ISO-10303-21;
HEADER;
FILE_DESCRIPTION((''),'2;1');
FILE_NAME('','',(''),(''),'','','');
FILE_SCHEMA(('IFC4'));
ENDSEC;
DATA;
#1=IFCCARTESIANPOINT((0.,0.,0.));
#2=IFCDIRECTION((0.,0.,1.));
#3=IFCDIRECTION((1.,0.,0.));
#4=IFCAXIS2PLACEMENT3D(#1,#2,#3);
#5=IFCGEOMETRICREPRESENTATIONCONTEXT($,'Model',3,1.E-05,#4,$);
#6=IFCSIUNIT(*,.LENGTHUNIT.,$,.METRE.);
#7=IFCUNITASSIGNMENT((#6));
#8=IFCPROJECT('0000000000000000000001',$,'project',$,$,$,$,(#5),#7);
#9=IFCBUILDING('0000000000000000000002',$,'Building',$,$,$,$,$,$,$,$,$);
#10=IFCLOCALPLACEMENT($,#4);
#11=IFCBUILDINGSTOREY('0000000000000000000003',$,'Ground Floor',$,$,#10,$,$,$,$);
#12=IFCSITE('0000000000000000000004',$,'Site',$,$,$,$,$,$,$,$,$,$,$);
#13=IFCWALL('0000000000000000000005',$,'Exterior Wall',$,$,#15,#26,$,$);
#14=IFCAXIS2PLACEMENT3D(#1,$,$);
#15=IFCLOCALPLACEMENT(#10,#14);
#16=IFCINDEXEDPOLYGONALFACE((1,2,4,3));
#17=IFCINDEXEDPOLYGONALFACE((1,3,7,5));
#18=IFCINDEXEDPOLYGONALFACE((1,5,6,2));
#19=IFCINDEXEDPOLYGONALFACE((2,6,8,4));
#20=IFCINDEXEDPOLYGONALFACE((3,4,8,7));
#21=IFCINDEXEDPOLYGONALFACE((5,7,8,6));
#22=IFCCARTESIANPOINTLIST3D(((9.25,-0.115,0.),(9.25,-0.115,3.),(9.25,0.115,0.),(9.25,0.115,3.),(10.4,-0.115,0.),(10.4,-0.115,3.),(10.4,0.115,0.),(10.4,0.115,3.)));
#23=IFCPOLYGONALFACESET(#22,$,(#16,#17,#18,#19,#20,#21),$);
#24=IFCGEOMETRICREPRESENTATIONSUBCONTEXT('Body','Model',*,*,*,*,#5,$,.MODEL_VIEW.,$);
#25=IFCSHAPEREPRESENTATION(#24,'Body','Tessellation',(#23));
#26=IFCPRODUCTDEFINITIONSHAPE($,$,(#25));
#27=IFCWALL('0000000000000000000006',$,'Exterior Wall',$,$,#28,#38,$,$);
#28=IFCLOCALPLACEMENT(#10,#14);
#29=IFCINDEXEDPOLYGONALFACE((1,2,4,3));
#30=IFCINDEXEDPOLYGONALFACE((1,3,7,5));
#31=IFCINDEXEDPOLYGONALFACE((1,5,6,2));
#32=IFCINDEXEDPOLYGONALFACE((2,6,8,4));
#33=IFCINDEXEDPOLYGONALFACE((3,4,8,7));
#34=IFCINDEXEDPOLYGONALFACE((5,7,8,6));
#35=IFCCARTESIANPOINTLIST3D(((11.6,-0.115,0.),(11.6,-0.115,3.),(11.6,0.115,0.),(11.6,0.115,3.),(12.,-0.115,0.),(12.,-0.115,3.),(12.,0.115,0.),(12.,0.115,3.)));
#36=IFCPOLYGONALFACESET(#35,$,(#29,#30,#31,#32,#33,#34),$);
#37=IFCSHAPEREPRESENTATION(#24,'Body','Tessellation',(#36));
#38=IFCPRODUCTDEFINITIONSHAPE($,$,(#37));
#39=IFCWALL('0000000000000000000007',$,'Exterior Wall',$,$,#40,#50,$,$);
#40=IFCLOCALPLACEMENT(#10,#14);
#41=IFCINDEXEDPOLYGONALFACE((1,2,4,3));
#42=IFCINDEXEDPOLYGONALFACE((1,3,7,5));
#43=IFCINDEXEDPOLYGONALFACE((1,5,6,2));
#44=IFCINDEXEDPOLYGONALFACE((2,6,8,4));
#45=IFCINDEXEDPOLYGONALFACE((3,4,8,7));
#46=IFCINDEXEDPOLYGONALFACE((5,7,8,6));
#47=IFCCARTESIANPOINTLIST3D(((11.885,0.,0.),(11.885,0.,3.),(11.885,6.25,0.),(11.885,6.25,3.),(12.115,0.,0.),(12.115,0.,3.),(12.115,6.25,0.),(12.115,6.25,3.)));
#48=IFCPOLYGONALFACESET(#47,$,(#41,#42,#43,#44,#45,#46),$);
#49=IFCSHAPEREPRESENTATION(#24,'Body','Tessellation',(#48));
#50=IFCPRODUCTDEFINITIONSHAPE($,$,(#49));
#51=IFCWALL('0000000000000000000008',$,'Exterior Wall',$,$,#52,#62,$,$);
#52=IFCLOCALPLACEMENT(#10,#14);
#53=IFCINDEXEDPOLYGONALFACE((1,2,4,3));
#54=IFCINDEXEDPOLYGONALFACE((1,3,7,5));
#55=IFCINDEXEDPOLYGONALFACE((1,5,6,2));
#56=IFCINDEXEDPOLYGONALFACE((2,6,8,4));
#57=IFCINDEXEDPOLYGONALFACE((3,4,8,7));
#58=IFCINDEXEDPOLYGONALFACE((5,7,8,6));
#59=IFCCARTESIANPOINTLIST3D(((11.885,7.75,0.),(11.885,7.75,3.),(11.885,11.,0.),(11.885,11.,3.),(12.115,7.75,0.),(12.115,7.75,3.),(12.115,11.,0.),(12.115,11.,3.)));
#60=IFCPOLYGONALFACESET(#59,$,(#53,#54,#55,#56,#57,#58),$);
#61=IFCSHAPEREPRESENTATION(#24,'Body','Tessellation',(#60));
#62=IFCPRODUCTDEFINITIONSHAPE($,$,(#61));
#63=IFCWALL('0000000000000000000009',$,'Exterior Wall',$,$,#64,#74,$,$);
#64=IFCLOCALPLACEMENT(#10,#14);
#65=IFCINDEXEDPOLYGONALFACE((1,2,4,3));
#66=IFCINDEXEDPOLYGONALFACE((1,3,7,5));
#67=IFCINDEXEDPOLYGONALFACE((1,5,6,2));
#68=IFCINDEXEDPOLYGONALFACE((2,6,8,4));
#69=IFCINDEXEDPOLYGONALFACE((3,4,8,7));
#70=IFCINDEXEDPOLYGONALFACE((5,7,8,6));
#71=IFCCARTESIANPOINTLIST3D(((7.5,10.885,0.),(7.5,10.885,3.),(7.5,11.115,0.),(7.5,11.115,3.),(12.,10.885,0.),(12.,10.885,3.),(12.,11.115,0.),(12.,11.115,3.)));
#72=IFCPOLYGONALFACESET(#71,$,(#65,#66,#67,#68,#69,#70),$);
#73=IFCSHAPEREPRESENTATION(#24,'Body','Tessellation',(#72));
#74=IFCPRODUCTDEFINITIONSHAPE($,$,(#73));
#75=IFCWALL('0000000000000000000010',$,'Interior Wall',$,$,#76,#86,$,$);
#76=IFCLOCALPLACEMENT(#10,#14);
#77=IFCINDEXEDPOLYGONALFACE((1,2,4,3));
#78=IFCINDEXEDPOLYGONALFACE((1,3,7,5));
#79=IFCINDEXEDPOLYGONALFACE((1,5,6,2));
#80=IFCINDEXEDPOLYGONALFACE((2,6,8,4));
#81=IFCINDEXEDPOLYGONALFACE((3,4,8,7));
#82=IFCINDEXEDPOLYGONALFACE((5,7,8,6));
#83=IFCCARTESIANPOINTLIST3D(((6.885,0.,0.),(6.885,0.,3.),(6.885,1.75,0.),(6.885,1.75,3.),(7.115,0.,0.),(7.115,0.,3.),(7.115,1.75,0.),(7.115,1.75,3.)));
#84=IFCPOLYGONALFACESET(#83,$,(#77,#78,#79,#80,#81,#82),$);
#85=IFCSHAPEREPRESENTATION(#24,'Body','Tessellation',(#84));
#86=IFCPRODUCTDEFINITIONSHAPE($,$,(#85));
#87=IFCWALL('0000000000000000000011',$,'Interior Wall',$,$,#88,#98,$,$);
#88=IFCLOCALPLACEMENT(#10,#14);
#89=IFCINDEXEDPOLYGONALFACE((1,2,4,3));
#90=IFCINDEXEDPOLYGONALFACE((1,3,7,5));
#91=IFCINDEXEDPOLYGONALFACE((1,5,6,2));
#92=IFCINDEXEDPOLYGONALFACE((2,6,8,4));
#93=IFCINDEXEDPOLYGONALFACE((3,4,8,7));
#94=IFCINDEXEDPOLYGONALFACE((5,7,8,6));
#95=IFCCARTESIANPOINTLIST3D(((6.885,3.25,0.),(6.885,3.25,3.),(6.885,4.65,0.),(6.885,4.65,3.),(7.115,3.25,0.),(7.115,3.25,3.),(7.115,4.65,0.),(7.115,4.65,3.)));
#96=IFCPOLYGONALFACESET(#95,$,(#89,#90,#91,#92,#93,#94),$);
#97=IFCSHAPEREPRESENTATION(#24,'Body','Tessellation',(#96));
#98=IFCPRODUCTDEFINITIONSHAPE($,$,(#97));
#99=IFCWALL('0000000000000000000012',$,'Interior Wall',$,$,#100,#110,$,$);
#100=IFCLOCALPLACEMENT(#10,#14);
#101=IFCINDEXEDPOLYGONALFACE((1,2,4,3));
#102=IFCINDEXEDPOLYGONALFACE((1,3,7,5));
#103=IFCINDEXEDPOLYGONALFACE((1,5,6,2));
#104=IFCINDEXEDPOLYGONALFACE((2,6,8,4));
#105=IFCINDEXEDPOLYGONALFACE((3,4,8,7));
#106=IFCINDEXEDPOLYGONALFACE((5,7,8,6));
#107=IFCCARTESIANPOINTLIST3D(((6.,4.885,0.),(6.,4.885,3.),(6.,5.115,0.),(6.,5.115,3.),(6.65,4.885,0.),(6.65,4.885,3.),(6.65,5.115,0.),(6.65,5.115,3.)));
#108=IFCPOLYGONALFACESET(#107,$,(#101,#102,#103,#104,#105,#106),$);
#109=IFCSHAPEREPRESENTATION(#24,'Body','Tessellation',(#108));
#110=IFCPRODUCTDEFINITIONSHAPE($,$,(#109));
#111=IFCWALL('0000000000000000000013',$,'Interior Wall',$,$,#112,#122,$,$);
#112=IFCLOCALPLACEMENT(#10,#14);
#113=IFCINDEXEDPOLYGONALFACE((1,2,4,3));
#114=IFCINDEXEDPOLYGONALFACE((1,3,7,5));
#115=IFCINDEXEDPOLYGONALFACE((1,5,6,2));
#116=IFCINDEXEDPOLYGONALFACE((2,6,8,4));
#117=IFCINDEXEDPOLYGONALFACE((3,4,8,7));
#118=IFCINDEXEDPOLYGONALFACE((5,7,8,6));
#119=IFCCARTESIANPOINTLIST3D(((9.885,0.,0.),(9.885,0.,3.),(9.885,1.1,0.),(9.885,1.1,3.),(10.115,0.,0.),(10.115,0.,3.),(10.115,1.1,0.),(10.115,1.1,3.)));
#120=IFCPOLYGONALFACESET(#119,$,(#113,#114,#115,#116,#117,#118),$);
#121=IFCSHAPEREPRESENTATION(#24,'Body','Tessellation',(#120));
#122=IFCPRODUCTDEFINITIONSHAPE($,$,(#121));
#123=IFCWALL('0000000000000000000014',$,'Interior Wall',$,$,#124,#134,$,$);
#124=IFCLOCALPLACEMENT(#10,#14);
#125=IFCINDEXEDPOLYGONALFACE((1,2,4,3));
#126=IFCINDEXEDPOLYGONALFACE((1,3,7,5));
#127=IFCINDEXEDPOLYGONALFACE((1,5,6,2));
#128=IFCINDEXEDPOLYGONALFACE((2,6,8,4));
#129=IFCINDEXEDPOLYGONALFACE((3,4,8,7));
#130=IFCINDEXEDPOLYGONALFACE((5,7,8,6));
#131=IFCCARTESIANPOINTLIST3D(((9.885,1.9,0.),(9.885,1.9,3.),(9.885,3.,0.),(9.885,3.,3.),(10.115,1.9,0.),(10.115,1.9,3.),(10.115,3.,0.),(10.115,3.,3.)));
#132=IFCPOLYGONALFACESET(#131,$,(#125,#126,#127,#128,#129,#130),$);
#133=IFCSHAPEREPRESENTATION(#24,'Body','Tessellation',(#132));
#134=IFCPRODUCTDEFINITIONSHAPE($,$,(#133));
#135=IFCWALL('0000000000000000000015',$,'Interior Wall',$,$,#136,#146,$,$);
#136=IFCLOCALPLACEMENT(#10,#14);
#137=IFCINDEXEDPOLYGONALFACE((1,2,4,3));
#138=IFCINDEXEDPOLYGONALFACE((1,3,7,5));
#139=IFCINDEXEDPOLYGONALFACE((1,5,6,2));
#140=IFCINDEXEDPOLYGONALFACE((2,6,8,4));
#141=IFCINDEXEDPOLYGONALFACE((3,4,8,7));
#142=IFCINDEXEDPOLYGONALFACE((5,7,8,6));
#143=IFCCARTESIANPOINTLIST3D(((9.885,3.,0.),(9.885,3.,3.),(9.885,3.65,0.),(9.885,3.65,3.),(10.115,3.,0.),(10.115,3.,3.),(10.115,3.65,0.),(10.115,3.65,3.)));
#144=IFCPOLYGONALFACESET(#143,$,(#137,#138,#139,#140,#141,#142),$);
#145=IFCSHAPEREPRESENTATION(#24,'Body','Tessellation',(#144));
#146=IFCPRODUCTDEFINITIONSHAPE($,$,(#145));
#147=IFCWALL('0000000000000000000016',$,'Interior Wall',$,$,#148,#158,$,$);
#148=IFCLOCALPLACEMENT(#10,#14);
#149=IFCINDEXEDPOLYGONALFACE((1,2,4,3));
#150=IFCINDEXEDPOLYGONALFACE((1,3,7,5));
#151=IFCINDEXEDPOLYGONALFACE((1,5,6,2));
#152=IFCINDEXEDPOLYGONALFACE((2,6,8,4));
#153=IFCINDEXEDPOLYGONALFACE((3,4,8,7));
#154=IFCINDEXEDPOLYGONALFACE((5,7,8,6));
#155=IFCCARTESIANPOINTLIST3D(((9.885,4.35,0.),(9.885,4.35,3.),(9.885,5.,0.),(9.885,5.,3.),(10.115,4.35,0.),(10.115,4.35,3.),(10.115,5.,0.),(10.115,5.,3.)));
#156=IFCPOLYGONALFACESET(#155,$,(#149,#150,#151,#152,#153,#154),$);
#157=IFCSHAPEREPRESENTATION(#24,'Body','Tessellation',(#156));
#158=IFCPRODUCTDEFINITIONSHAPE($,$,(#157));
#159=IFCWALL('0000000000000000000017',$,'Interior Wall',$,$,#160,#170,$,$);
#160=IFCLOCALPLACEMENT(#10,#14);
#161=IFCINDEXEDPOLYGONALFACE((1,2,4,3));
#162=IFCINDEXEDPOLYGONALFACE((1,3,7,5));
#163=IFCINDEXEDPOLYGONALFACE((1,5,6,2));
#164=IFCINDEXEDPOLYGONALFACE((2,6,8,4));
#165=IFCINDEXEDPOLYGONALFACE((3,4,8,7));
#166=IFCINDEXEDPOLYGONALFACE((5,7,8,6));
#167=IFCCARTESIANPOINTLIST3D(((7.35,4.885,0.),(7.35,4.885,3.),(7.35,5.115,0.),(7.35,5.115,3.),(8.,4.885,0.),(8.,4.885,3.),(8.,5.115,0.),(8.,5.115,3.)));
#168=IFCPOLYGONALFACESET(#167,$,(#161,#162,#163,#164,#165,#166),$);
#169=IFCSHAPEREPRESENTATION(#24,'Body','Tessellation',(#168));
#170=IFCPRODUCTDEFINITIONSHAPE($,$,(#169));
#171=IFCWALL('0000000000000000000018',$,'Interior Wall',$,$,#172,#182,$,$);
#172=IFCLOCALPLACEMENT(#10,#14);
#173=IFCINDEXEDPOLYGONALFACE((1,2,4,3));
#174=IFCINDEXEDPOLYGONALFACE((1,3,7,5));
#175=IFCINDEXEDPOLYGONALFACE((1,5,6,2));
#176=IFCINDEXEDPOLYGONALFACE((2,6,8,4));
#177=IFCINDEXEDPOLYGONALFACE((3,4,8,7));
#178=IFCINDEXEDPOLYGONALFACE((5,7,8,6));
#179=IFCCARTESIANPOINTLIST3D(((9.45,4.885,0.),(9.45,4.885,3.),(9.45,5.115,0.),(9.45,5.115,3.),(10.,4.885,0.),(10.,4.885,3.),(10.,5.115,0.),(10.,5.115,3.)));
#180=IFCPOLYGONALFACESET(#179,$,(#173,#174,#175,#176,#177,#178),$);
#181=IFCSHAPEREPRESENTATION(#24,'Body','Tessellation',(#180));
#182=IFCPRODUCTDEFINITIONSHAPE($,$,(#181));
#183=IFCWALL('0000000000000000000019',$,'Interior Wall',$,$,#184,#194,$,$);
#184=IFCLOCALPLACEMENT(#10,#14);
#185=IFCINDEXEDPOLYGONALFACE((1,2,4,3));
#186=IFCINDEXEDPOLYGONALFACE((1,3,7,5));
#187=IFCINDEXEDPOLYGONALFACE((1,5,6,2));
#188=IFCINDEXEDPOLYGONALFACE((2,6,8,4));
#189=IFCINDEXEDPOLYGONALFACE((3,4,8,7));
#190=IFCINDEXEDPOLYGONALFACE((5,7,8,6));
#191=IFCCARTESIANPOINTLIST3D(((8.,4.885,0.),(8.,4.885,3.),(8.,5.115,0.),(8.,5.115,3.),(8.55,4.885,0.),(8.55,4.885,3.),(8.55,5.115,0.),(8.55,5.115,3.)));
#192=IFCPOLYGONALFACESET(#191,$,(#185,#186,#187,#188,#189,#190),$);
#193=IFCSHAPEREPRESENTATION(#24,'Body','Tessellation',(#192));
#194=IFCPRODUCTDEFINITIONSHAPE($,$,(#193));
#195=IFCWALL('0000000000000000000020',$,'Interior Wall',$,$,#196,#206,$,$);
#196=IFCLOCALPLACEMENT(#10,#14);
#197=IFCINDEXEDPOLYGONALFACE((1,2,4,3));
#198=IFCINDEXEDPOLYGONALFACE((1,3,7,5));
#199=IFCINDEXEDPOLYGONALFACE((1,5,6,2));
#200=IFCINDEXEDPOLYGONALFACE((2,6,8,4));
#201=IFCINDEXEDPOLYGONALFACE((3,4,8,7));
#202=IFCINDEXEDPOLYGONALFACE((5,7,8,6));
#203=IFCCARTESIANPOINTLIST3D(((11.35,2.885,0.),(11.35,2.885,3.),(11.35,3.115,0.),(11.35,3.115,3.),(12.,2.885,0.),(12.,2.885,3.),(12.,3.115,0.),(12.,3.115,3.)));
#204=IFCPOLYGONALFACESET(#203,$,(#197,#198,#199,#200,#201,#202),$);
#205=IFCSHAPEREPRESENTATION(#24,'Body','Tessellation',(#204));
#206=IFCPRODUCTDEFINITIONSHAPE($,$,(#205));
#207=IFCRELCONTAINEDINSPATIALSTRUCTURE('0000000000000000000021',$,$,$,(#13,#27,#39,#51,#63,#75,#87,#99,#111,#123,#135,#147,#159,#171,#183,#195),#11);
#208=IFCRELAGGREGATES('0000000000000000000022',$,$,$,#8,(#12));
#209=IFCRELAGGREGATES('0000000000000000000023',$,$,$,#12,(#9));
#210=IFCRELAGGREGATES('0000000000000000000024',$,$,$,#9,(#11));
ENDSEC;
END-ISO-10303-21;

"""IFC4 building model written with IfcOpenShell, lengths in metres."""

from ifc_helpers import new_model, si_unit, frame, origin_with_axes, place, context, subcontext, project, spatial, indexed_curve, outline, extrude, element, save


model = new_model("IFC4")

# Units and contexts
model_context = context("Model", 3, precision=1e-05, world=origin_with_axes())
body_context = subcontext(model_context, "Body", "Model", "MODEL_VIEW")
ifc_project = project(units=[si_unit("LENGTHUNIT", "METRE")], contexts=[model_context])

# Site, building, storey
site = spatial("IfcSite", under=ifc_project, Name="Site")
building = spatial("IfcBuilding", under=site, Name="Building")
storey_placement = place(None, origin_with_axes())
storey = spatial("IfcBuildingStorey", under=building, at=storey_placement, Name="Ground Floor")

# Walls
wall_1_placement = place(storey_placement, frame((9.25, 0.0, 0.0), z_axis=(0.0, 0.0, 1.0), x_axis=(1.0, 0.0, 0.0)))
element("IfcWall", 1, at=wall_1_placement, inside=storey, Name="Exterior Wall", context=body_context, shape_type="SweptSolid", body=[
    extrude(outline(indexed_curve([(0.0, 0.0), (0.0, 0.23), (1.15, 0.23), (1.15, 0.0), (0.0, 0.0)], self_intersect=False)), frame((0.0, -0.115, 0.0), z_axis=(0.0, 0.0, 1.0), x_axis=(1.0, 0.0, 0.0)), (0.0, 0.0, 1.0), 3.0),
])
wall_2_placement = place(storey_placement, frame((11.6, 0.0, 0.0), z_axis=(0.0, 0.0, 1.0), x_axis=(1.0, 0.0, 0.0)))
element("IfcWall", 2, at=wall_2_placement, inside=storey, Name="Exterior Wall", context=body_context, shape_type="SweptSolid", body=[
    extrude(outline(indexed_curve([(0.0, 0.0), (0.0, 0.23), (0.4, 0.23), (0.4, 0.0), (0.0, 0.0)], self_intersect=False)), frame((0.0, -0.115, 0.0), z_axis=(0.0, 0.0, 1.0), x_axis=(1.0, 0.0, 0.0)), (0.0, 0.0, 1.0), 3.0),
])
wall_3_placement = place(storey_placement, frame((12.0, 0.0, 0.0), z_axis=(0.0, 0.0, 1.0), x_axis=(0.0, 1.0, 0.0)))
element("IfcWall", 3, at=wall_3_placement, inside=storey, Name="Exterior Wall", context=body_context, shape_type="SweptSolid", body=[
    extrude(outline(indexed_curve([(0.0, 0.0), (0.0, 0.23), (6.25, 0.23), (6.25, 0.0), (0.0, 0.0)], self_intersect=False)), frame((0.0, -0.115, 0.0), z_axis=(0.0, 0.0, 1.0), x_axis=(1.0, 0.0, 0.0)), (0.0, 0.0, 1.0), 3.0),
])
wall_4_placement = place(storey_placement, frame((12.0, 7.75, 0.0), z_axis=(0.0, 0.0, 1.0), x_axis=(0.0, 1.0, 0.0)))
element("IfcWall", 4, at=wall_4_placement, inside=storey, Name="Exterior Wall", context=body_context, shape_type="SweptSolid", body=[
    extrude(outline(indexed_curve([(0.0, 0.0), (0.0, 0.23), (3.25, 0.23), (3.25, 0.0), (0.0, 0.0)], self_intersect=False)), frame((0.0, -0.115, 0.0), z_axis=(0.0, 0.0, 1.0), x_axis=(1.0, 0.0, 0.0)), (0.0, 0.0, 1.0), 3.0),
])
wall_5_placement = place(storey_placement, frame((12.0, 11.0, 0.0), z_axis=(0.0, 0.0, 1.0), x_axis=(-1.0, 0.0, 0.0)))
element("IfcWall", 5, at=wall_5_placement, inside=storey, Name="Exterior Wall", context=body_context, shape_type="SweptSolid", body=[
    extrude(outline(indexed_curve([(0.0, 0.0), (0.0, 0.23), (4.5, 0.23), (4.5, 0.0), (0.0, 0.0)], self_intersect=False)), frame((0.0, -0.115, 0.0), z_axis=(0.0, 0.0, 1.0), x_axis=(1.0, 0.0, 0.0)), (0.0, 0.0, 1.0), 3.0),
])
wall_6_placement = place(storey_placement, frame((7.0, 0.0, 0.0), z_axis=(0.0, 0.0, 1.0), x_axis=(0.0, 1.0, 0.0)))
element("IfcWall", 6, at=wall_6_placement, inside=storey, Name="Interior Wall", context=body_context, shape_type="SweptSolid", body=[
    extrude(outline(indexed_curve([(0.0, 0.0), (0.0, 0.23), (1.75, 0.23), (1.75, 0.0), (0.0, 0.0)], self_intersect=False)), frame((0.0, -0.115, 0.0), z_axis=(0.0, 0.0, 1.0), x_axis=(1.0, 0.0, 0.0)), (0.0, 0.0, 1.0), 3.0),
])
wall_7_placement = place(storey_placement, frame((7.0, 3.25, 0.0), z_axis=(0.0, 0.0, 1.0), x_axis=(0.0, 1.0, 0.0)))
element("IfcWall", 7, at=wall_7_placement, inside=storey, Name="Interior Wall", context=body_context, shape_type="SweptSolid", body=[
    extrude(outline(indexed_curve([(0.0, 0.0), (0.0, 0.23), (1.4, 0.23), (1.4, 0.0), (0.0, 0.0)], self_intersect=False)), frame((0.0, -0.115, 0.0), z_axis=(0.0, 0.0, 1.0), x_axis=(1.0, 0.0, 0.0)), (0.0, 0.0, 1.0), 3.0),
])
wall_8_placement = place(storey_placement, frame((6.65, 5.0, 0.0), z_axis=(0.0, 0.0, 1.0), x_axis=(-1.0, 0.0, 0.0)))
element("IfcWall", 8, at=wall_8_placement, inside=storey, Name="Interior Wall", context=body_context, shape_type="SweptSolid", body=[
    extrude(outline(indexed_curve([(0.0, 0.0), (0.0, 0.23), (0.65, 0.23), (0.65, 0.0), (0.0, 0.0)], self_intersect=False)), frame((0.0, -0.115, 0.0), z_axis=(0.0, 0.0, 1.0), x_axis=(1.0, 0.0, 0.0)), (0.0, 0.0, 1.0), 3.0),
])
for number, where, z_axis, x_axis, name in (
    (9, (10.0, 0.0, 0.0), (0.0, 0.0, 1.0), (0.0, 1.0, 0.0), "Interior Wall"),
    (10, (10.0, 1.9, 0.0), (0.0, 0.0, 1.0), (0.0, 1.0, 0.0), "Interior Wall"),
):
    element("IfcWall", number, at=place(storey_placement, frame(where, z_axis=z_axis, x_axis=x_axis)), inside=storey, Name=name, context=body_context, shape_type="SweptSolid", body=[
        extrude(outline(indexed_curve([(0.0, 0.0), (0.0, 0.23), (1.1, 0.23), (1.1, 0.0), (0.0, 0.0)], self_intersect=False)), frame((0.0, -0.115, 0.0), z_axis=(0.0, 0.0, 1.0), x_axis=(1.0, 0.0, 0.0)), (0.0, 0.0, 1.0), 3.0),
    ])
wall_9_placement = place(storey_placement, frame((10.0, 3.0, 0.0), z_axis=(0.0, 0.0, 1.0), x_axis=(0.0, 1.0, 0.0)))
element("IfcWall", 11, at=wall_9_placement, inside=storey, Name="Interior Wall", context=body_context, shape_type="SweptSolid", body=[
    extrude(outline(indexed_curve([(0.0, 0.0), (0.0, 0.23), (0.65, 0.23), (0.65, 0.0), (0.0, 0.0)], self_intersect=False)), frame((0.0, -0.115, 0.0), z_axis=(0.0, 0.0, 1.0), x_axis=(1.0, 0.0, 0.0)), (0.0, 0.0, 1.0), 3.0),
])
for number, where, z_axis, x_axis, name in (
    (12, (10.0, 4.35, 0.0), (0.0, 0.0, 1.0), (0.0, 1.0, 0.0), "Interior Wall"),
    (13, (8.0, 5.0, 0.0), (0.0, 0.0, 1.0), (-1.0, 0.0, 0.0), "Interior Wall"),
):
    element("IfcWall", number, at=place(storey_placement, frame(where, z_axis=z_axis, x_axis=x_axis)), inside=storey, Name=name, context=body_context, shape_type="SweptSolid", body=[
        extrude(outline(indexed_curve([(0.0, 0.0), (0.0, 0.23), (0.65, 0.23), (0.65, 0.0), (0.0, 0.0)], self_intersect=False)), frame((0.0, -0.115, 0.0), z_axis=(0.0, 0.0, 1.0), x_axis=(1.0, 0.0, 0.0)), (0.0, 0.0, 1.0), 3.0),
    ])
for number, where, z_axis, x_axis, name in (
    (14, (10.0, 5.0, 0.0), (0.0, 0.0, 1.0), (-1.0, 0.0, 0.0), "Interior Wall"),
    (15, (8.55, 5.0, 0.0), (0.0, 0.0, 1.0), (-1.0, 0.0, 0.0), "Interior Wall"),
):
    element("IfcWall", number, at=place(storey_placement, frame(where, z_axis=z_axis, x_axis=x_axis)), inside=storey, Name=name, context=body_context, shape_type="SweptSolid", body=[
        extrude(outline(indexed_curve([(0.0, 0.0), (0.0, 0.23), (0.55, 0.23), (0.55, 0.0), (0.0, 0.0)], self_intersect=False)), frame((0.0, -0.115, 0.0), z_axis=(0.0, 0.0, 1.0), x_axis=(1.0, 0.0, 0.0)), (0.0, 0.0, 1.0), 3.0),
    ])
for number, where, z_axis, x_axis, name in (
    (16, (12.0, 3.0, 0.0), (0.0, 0.0, 1.0), (-1.0, 0.0, 0.0), "Interior Wall"),
):
    element("IfcWall", number, at=place(storey_placement, frame(where, z_axis=z_axis, x_axis=x_axis)), inside=storey, Name=name, context=body_context, shape_type="SweptSolid", body=[
        extrude(outline(indexed_curve([(0.0, 0.0), (0.0, 0.23), (0.65, 0.23), (0.65, 0.0), (0.0, 0.0)], self_intersect=False)), frame((0.0, -0.115, 0.0), z_axis=(0.0, 0.0, 1.0), x_axis=(1.0, 0.0, 0.0)), (0.0, 0.0, 1.0), 3.0),
    ])

save(model, "model.ifc")
